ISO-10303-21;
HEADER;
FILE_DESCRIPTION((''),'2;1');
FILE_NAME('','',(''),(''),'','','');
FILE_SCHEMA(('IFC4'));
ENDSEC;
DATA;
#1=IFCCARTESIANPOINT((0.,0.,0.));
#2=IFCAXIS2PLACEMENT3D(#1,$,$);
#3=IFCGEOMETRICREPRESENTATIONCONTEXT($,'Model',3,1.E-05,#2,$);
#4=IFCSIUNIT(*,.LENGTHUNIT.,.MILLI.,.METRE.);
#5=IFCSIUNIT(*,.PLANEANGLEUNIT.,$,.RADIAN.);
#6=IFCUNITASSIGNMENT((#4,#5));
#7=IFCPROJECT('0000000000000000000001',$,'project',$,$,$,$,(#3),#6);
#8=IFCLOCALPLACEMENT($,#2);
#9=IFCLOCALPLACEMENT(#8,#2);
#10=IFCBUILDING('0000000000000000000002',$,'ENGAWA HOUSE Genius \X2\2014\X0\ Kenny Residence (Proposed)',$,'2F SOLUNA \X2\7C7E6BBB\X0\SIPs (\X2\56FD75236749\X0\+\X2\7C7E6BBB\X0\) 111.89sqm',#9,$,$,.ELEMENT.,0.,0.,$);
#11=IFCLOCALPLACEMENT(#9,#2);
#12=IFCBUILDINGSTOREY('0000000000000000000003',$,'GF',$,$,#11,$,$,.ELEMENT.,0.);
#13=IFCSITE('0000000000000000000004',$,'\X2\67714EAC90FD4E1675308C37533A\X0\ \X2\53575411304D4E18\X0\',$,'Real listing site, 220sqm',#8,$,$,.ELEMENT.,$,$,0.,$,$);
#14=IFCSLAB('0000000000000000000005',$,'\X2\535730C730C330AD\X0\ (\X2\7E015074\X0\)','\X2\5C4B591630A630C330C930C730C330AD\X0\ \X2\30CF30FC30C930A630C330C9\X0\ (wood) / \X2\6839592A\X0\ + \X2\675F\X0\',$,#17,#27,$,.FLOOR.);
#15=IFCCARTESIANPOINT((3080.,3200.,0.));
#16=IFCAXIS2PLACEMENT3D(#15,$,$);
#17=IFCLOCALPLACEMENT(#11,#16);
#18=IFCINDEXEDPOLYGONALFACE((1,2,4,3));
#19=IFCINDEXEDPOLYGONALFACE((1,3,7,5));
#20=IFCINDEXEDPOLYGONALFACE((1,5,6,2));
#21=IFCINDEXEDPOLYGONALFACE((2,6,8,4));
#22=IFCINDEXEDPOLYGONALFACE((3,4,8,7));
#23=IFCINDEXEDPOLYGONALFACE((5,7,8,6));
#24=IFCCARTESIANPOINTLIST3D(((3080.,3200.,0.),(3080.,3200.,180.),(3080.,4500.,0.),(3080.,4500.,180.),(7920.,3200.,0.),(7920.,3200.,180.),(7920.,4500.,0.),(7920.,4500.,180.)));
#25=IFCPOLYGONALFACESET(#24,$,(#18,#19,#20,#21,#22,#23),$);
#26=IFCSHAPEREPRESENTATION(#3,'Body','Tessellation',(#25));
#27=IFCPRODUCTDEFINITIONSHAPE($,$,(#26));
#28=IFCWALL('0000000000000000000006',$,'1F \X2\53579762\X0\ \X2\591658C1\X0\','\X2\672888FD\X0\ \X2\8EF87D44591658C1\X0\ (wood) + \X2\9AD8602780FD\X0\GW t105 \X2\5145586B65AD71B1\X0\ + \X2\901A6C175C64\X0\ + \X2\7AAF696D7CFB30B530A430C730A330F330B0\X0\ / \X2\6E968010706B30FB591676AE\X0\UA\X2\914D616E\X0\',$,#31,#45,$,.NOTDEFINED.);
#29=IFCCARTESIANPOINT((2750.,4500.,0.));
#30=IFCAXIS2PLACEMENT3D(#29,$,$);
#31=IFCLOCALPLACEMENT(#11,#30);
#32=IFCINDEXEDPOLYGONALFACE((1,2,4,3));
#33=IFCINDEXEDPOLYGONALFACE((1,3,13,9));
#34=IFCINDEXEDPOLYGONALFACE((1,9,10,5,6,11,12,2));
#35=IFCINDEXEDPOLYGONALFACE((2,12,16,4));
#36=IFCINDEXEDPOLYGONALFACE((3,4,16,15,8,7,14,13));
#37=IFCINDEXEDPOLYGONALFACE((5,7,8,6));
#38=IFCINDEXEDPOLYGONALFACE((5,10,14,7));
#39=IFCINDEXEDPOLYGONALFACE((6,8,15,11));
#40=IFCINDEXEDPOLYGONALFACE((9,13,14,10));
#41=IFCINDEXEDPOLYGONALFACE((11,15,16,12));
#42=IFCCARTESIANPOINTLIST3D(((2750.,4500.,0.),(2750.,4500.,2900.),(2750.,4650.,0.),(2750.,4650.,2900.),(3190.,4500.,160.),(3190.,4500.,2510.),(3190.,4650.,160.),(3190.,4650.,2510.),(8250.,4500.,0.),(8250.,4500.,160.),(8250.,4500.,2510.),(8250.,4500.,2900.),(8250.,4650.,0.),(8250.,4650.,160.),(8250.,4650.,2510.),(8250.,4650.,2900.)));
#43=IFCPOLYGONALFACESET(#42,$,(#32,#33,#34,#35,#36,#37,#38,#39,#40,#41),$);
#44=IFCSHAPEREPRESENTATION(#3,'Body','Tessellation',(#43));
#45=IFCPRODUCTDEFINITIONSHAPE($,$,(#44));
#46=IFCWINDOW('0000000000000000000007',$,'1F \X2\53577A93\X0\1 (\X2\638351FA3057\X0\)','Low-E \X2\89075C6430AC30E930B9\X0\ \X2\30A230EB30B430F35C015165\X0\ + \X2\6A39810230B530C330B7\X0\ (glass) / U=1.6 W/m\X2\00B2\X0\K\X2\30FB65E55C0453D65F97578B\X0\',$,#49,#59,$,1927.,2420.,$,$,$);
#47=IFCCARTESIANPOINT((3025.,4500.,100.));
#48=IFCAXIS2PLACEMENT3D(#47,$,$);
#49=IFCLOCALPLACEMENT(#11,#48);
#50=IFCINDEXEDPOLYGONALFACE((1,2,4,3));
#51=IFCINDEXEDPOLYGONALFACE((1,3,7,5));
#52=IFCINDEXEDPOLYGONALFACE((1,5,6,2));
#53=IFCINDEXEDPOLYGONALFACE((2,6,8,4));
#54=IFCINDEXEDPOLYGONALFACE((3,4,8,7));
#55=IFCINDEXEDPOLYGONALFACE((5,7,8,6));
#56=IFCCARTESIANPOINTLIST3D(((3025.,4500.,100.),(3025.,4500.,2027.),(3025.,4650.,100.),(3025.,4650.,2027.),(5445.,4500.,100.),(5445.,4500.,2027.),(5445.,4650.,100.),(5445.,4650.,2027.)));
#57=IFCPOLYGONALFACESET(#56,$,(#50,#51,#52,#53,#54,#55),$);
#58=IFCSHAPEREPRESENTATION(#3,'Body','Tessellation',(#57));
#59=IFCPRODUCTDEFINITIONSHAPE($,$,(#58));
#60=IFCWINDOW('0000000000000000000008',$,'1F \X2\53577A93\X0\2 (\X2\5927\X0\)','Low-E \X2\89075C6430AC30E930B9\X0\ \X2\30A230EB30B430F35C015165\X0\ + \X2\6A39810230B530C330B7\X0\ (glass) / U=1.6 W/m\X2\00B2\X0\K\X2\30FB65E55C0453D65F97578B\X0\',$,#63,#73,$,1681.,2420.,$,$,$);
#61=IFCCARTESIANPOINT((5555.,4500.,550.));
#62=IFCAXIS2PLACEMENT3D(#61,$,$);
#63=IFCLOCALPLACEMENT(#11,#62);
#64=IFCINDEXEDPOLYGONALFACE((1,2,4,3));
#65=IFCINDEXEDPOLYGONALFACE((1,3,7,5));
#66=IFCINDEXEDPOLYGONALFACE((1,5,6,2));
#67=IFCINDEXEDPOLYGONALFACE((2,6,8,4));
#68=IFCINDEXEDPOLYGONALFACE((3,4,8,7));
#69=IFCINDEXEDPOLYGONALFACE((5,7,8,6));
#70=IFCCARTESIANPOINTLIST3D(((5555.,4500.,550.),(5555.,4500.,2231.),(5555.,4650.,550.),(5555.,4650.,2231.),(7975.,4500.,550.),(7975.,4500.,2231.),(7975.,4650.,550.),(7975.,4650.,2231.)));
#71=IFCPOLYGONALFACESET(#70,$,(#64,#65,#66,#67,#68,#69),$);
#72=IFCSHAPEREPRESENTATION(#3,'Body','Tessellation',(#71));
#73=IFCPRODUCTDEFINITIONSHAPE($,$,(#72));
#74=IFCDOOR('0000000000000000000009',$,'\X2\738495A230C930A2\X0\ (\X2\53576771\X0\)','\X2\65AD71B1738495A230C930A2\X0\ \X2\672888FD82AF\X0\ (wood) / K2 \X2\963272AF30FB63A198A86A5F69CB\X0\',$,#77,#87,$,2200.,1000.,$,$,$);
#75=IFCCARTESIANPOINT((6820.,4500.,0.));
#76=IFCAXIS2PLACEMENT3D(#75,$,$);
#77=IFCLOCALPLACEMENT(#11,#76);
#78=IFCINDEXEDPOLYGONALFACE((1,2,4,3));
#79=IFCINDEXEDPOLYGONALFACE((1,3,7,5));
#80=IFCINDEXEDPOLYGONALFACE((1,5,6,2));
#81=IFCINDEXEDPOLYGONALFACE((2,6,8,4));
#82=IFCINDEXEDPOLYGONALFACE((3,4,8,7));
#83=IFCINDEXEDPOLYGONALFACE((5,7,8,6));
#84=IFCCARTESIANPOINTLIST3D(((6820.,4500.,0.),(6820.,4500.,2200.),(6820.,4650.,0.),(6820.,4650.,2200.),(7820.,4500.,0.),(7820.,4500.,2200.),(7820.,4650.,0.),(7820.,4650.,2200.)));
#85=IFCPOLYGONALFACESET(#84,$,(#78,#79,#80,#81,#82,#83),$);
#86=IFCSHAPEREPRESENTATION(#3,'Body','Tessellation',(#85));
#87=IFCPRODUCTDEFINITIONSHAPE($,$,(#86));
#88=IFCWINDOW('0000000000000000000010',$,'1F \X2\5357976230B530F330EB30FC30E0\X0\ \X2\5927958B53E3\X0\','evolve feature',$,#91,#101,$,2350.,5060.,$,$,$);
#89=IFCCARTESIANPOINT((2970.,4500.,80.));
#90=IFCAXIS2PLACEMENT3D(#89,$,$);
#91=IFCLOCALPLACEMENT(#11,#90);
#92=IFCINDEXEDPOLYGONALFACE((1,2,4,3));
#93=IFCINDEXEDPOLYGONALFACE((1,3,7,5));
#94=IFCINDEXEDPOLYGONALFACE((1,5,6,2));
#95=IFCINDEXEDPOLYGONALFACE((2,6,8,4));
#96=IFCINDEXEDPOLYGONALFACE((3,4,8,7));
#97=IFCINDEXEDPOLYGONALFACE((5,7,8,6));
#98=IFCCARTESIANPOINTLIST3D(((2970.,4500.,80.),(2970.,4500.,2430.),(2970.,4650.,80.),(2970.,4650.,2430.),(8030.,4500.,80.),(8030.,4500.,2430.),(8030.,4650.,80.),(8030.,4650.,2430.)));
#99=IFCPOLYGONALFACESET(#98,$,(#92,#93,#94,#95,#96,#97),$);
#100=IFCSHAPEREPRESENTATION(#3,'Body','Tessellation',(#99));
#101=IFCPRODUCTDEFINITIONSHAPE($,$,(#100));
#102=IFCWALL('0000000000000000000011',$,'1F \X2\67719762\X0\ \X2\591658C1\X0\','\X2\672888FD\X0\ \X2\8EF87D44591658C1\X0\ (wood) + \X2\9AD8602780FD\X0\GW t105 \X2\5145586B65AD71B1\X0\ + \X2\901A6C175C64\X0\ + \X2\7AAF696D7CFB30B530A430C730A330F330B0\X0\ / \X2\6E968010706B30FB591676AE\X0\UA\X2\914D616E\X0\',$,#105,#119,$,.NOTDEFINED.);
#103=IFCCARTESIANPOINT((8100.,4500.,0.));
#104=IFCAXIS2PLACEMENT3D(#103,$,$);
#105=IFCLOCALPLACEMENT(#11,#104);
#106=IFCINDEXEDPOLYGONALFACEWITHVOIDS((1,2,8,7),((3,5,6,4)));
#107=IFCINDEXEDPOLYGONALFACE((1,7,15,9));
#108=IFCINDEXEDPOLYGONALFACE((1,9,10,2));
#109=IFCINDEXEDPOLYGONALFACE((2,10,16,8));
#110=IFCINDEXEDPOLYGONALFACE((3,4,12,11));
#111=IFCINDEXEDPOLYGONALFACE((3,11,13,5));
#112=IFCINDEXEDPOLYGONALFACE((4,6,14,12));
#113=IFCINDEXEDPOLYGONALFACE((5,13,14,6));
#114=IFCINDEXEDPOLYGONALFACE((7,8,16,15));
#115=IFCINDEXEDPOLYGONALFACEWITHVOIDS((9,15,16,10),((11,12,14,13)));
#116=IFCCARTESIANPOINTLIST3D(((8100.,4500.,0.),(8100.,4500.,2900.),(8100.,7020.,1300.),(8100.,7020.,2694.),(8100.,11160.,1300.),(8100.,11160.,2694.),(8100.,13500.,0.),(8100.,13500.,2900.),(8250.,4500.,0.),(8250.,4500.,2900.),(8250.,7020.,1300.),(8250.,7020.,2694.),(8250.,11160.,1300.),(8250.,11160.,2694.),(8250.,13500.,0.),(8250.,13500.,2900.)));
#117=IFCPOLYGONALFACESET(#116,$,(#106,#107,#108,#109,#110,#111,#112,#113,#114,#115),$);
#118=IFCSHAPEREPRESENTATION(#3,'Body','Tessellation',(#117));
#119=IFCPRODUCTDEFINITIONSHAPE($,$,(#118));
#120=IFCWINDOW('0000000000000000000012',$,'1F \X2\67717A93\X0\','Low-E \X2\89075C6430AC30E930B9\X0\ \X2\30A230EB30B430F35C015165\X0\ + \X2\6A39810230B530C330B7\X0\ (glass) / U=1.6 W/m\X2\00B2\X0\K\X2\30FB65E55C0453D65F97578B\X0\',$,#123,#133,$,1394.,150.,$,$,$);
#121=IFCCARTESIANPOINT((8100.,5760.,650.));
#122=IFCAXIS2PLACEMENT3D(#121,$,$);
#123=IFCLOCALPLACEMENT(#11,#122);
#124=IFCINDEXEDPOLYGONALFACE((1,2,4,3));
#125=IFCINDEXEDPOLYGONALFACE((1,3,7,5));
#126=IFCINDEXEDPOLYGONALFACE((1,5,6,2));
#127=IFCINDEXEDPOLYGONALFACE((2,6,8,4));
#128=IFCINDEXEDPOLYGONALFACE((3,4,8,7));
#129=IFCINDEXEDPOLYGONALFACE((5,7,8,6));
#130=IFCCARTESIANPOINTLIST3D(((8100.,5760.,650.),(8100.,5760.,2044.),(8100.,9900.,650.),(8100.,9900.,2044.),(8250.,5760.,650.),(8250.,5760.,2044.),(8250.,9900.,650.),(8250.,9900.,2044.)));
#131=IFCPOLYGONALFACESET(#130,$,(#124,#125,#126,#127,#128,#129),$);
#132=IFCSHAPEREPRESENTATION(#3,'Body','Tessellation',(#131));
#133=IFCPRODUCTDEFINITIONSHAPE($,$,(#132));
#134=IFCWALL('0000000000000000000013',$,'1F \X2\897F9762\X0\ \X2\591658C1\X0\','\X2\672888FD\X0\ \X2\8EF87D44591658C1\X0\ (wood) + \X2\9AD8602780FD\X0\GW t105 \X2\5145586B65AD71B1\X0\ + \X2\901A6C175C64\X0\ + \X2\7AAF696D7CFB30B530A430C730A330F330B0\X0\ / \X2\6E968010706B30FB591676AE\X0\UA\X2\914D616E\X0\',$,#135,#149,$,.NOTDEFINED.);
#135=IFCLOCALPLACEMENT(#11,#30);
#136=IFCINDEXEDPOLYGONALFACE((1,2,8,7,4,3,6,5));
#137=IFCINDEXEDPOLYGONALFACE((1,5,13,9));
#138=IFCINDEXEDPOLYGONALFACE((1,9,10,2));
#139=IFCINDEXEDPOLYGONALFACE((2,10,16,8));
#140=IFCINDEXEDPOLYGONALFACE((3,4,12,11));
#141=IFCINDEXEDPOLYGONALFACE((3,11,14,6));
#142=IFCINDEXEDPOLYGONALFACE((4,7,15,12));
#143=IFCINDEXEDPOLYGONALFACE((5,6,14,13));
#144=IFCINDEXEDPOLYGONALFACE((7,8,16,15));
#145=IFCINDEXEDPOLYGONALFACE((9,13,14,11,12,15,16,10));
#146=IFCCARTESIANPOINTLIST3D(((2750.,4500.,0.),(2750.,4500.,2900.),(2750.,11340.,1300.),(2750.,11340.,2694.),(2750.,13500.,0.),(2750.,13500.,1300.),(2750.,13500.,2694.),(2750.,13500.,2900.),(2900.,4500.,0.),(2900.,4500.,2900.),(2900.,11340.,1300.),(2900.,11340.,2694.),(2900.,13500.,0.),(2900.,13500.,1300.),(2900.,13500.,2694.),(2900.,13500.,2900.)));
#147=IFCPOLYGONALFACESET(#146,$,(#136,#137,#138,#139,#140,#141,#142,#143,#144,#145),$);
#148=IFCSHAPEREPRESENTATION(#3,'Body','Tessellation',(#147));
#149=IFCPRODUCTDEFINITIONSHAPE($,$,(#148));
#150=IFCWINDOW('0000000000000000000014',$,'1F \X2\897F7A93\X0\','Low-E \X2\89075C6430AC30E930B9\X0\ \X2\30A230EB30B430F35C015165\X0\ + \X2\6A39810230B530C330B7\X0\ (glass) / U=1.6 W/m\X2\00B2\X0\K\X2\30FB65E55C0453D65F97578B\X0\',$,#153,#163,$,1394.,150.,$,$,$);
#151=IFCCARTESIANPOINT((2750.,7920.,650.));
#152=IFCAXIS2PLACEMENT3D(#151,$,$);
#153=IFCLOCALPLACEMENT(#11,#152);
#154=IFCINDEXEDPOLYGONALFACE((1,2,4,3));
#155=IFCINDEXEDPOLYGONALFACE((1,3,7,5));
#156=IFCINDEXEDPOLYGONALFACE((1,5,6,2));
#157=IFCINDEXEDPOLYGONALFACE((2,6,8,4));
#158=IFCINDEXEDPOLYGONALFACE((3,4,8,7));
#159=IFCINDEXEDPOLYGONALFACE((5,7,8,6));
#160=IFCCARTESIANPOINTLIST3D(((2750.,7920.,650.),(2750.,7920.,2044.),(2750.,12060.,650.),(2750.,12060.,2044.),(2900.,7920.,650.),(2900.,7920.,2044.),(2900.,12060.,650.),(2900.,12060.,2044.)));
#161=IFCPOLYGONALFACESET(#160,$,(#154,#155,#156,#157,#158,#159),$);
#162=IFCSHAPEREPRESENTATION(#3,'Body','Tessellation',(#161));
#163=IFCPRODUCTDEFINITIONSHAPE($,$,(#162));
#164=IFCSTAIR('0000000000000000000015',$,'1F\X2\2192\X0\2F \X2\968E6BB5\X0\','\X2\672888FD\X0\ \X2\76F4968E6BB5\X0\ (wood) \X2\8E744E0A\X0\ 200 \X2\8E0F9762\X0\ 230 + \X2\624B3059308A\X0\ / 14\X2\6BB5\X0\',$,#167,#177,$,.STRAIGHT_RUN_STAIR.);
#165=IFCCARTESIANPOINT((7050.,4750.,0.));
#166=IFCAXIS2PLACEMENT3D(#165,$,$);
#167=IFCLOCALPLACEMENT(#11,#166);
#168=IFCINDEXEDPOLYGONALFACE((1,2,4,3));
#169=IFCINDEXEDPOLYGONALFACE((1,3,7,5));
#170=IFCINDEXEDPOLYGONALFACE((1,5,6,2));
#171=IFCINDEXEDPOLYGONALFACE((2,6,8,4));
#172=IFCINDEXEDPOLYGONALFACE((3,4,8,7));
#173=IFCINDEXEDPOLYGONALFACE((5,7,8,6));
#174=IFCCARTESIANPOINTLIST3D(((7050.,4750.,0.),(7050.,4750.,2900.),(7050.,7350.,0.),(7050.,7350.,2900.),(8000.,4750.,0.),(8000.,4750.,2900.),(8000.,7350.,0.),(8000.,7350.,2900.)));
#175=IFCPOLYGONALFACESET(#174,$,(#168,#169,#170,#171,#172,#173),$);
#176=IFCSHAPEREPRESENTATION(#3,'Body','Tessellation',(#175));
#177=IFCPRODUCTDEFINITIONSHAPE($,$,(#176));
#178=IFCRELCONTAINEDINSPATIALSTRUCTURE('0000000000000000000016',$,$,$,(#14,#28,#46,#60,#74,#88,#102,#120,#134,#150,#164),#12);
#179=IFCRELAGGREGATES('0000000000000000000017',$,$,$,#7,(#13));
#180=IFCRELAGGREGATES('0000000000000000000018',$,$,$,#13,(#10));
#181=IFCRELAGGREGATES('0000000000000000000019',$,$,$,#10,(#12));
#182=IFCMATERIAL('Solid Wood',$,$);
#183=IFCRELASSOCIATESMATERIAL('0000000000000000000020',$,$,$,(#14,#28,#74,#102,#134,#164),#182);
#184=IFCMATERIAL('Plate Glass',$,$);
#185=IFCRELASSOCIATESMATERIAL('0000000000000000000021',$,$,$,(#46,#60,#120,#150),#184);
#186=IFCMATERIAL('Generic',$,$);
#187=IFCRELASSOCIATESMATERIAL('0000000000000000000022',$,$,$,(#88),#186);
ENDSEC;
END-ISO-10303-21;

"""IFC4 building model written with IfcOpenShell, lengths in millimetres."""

from ifc_helpers import new_model, si_unit, frame, frame_2d, origin, place, context, project, spatial, rectangle, extrude, material, element, fill, save


model = new_model("IFC4")

# Units and contexts
model_context = context("Model", 3, precision=1e-05, world=origin())
ifc_project = project(units=[si_unit("LENGTHUNIT", "METRE", prefix="MILLI"), si_unit("PLANEANGLEUNIT", "RADIAN")], contexts=[model_context])

# Site, building, storey
site_placement = place(None, origin())
site = spatial("IfcSite", under=ifc_project, at=site_placement, Name="東京都世田谷区 南向き丘", ObjectType="Real listing site, 220sqm", CompositionType="ELEMENT", RefElevation=0.0)
building_placement = place(site_placement, origin())
building = spatial("IfcBuilding", under=site, at=building_placement, Name="ENGAWA HOUSE Genius — Kenny Residence (Proposed)", ObjectType="2F SOLUNA 籾殻SIPs (国産杉+籾殻) 111.89sqm", CompositionType="ELEMENT", ElevationOfRefHeight=0.0, ElevationOfTerrain=0.0)
storey_placement = place(building_placement, origin())
storey = spatial("IfcBuildingStorey", under=building, at=storey_placement, Name="GF", CompositionType="ELEMENT", Elevation=0.0)

# Slab
ifc_material_1 = material(Name="Solid Wood")
slab_1_placement = place(storey_placement, frame((3080.0, 3200.0, 0.0)))
element("IfcSlab", 1, at=slab_1_placement, inside=storey, material=ifc_material_1, Name="南デッキ (縁側)", Description="屋外ウッドデッキ ハードウッド (wood) / 根太 + 束", PredefinedType="FLOOR", context=model_context, shape_type="SweptSolid", body=[
    extrude(rectangle(XDim=4840.0, YDim=1300.0, at=frame_2d((2420.0, 650.0))), frame((3080.0, 3200.0, 0.0)), (0.0, 0.0, 1.0), 180.0),
])
ifc_material_2 = material(Name="Generic")

# Wall, openings, windows, door
wall_1_placement = place(storey_placement, frame((2750.0, 4500.0, 0.0)))
wall_1 = element("IfcWall", 2, at=wall_1_placement, inside=storey, material=ifc_material_1, Name="1F 南面 外壁", Description="木製 軸組外壁 (wood) + 高性能GW t105 充填断熱 + 通気層 + 窯業系サイディング / 準耐火・外皮UA配慮", PredefinedType="NOTDEFINED", context=model_context, shape_type="SweptSolid", body=[
    extrude(rectangle(XDim=5500.0, YDim=150.0, at=frame_2d((2750.0, 75.0))), frame((2750.0, 4500.0, 0.0)), (0.0, 0.0, 1.0), 2900.0),
])
opening_1_placement = place(storey_placement, frame((3025.0, 4500.0, 100.0)))
opening_1 = element("IfcOpeningElement", 3, at=opening_1_placement, cuts=wall_1, PredefinedType="NOTDEFINED", context=model_context, shape_type="SweptSolid", body=[
    extrude(rectangle(XDim=2420.0, YDim=150.0, at=frame_2d((1210.0, 75.0))), frame((3025.0, 4500.0, 100.0)), (0.0, 0.0, 1.0), 1927.0),
])
opening_2_placement = place(storey_placement, frame((5555.0, 4500.0, 550.0)))
opening_2 = element("IfcOpeningElement", 4, at=opening_2_placement, cuts=wall_1, PredefinedType="NOTDEFINED", context=model_context, shape_type="SweptSolid", body=[
    extrude(rectangle(XDim=2420.0, YDim=150.0, at=frame_2d((1210.0, 75.0))), frame((5555.0, 4500.0, 550.0)), (0.0, 0.0, 1.0), 1681.0),
])
opening_3_placement = place(storey_placement, frame((6820.0, 4500.0, 0.0)))
opening_3 = element("IfcOpeningElement", 5, at=opening_3_placement, cuts=wall_1, PredefinedType="NOTDEFINED", context=model_context, shape_type="SweptSolid", body=[
    extrude(rectangle(XDim=1000.0, YDim=150.0, at=frame_2d((500.0, 75.0))), frame((6820.0, 4500.0, 0.0)), (0.0, 0.0, 1.0), 2200.0),
])
opening_4_placement = place(storey_placement, frame((2970.0, 4500.0, 80.0)))
opening_4 = element("IfcOpeningElement", 6, at=opening_4_placement, cuts=wall_1, PredefinedType="NOTDEFINED", context=model_context, shape_type="SweptSolid", body=[
    extrude(rectangle(XDim=5060.0, YDim=150.0, at=frame_2d((2530.0, 75.0))), frame((2970.0, 4500.0, 80.0)), (0.0, 0.0, 1.0), 2350.0),
])
ifc_material_3 = material(Name="Plate Glass")
window_1_placement = place(storey_placement, frame((3025.0, 4500.0, 100.0)))
window_1 = element("IfcWindow", 7, at=window_1_placement, inside=storey, material=ifc_material_3, Name="1F 南窓1 (掃出し)", Description="Low-E 複層ガラス アルゴン封入 + 樹脂サッシ (glass) / U=1.6 W/m²K・日射取得型", OverallHeight=1927.0, OverallWidth=2420.0, context=model_context, shape_type="SweptSolid", body=[
    extrude(rectangle(XDim=2420.0, YDim=150.0, at=frame_2d((1210.0, 75.0))), frame((3025.0, 4500.0, 100.0)), (0.0, 0.0, 1.0), 1927.0),
])
fill(opening_1, window_1)
window_2_placement = place(storey_placement, frame((5555.0, 4500.0, 550.0)))
window_2 = element("IfcWindow", 8, at=window_2_placement, inside=storey, material=ifc_material_3, Name="1F 南窓2 (大)", Description="Low-E 複層ガラス アルゴン封入 + 樹脂サッシ (glass) / U=1.6 W/m²K・日射取得型", OverallHeight=1681.0, OverallWidth=2420.0, context=model_context, shape_type="SweptSolid", body=[
    extrude(rectangle(XDim=2420.0, YDim=150.0, at=frame_2d((1210.0, 75.0))), frame((5555.0, 4500.0, 550.0)), (0.0, 0.0, 1.0), 1681.0),
])
fill(opening_2, window_2)
door_placement = place(storey_placement, frame((6820.0, 4500.0, 0.0)))
door = element("IfcDoor", 9, at=door_placement, inside=storey, material=ifc_material_1, Name="玄関ドア (南東)", Description="断熱玄関ドア 木製芯 (wood) / K2 防犯・採風機構", OverallHeight=2200.0, OverallWidth=1000.0, context=model_context, shape_type="SweptSolid", body=[
    extrude(rectangle(XDim=1000.0, YDim=150.0, at=frame_2d((500.0, 75.0))), frame((6820.0, 4500.0, 0.0)), (0.0, 0.0, 1.0), 2200.0),
])
fill(opening_3, door)
window_3_placement = place(storey_placement, frame((2970.0, 4500.0, 80.0)))
window_3 = element("IfcWindow", 10, at=window_3_placement, inside=storey, material=ifc_material_2, Name="1F 南面サンルーム 大開口", Description="evolve feature", OverallHeight=2350.0, OverallWidth=5060.0, context=model_context, shape_type="SweptSolid", body=[
    extrude(rectangle(XDim=5060.0, YDim=150.0, at=frame_2d((2530.0, 75.0))), frame((2970.0, 4500.0, 80.0)), (0.0, 0.0, 1.0), 2350.0),
])
fill(opening_4, window_3)

# Walls, openings, windows
wall_2_placement = place(storey_placement, frame((8100.0, 4500.0, 0.0)))
wall_2 = element("IfcWall", 11, at=wall_2_placement, inside=storey, material=ifc_material_1, Name="1F 東面 外壁", Description="木製 軸組外壁 (wood) + 高性能GW t105 充填断熱 + 通気層 + 窯業系サイディング / 準耐火・外皮UA配慮", PredefinedType="NOTDEFINED", context=model_context, shape_type="SweptSolid", body=[
    extrude(rectangle(XDim=150.0, YDim=9000.0, at=frame_2d((75.0, 4500.0))), frame((8100.0, 4500.0, 0.0)), (0.0, 0.0, 1.0), 2900.0),
])
opening_5_placement = place(storey_placement, frame((8100.0, 5760.0, 650.0)))
opening_5 = element("IfcOpeningElement", 12, at=opening_5_placement, cuts=wall_2, PredefinedType="NOTDEFINED", context=model_context, shape_type="SweptSolid", body=[
    extrude(rectangle(XDim=150.0, YDim=4140.0, at=frame_2d((75.0, 2070.0))), frame((8100.0, 5760.0, 650.0)), (0.0, 0.0, 1.0), 1394.0),
])
window_4_placement = place(storey_placement, frame((8100.0, 5760.0, 650.0)))
window_4 = element("IfcWindow", 13, at=window_4_placement, inside=storey, material=ifc_material_3, Name="1F 東窓", Description="Low-E 複層ガラス アルゴン封入 + 樹脂サッシ (glass) / U=1.6 W/m²K・日射取得型", OverallHeight=1394.0, OverallWidth=150.0, context=model_context, shape_type="SweptSolid", body=[
    extrude(rectangle(XDim=150.0, YDim=4140.0, at=frame_2d((75.0, 2070.0))), frame((8100.0, 5760.0, 650.0)), (0.0, 0.0, 1.0), 1394.0),
])
fill(opening_5, window_4)
wall_3_placement = place(storey_placement, frame((2750.0, 4500.0, 0.0)))
wall_3 = element("IfcWall", 14, at=wall_3_placement, inside=storey, material=ifc_material_1, Name="1F 西面 外壁", Description="木製 軸組外壁 (wood) + 高性能GW t105 充填断熱 + 通気層 + 窯業系サイディング / 準耐火・外皮UA配慮", PredefinedType="NOTDEFINED", context=model_context, shape_type="SweptSolid", body=[
    extrude(rectangle(XDim=150.0, YDim=9000.0, at=frame_2d((75.0, 4500.0))), frame((2750.0, 4500.0, 0.0)), (0.0, 0.0, 1.0), 2900.0),
])
opening_6_placement = place(storey_placement, frame((2750.0, 7920.0, 650.0)))
opening_6 = element("IfcOpeningElement", 15, at=opening_6_placement, cuts=wall_3, PredefinedType="NOTDEFINED", context=model_context, shape_type="SweptSolid", body=[
    extrude(rectangle(XDim=150.0, YDim=4140.0, at=frame_2d((75.0, 2070.0))), frame((2750.0, 7920.0, 650.0)), (0.0, 0.0, 1.0), 1394.0),
])
window_5_placement = place(storey_placement, frame((2750.0, 7920.0, 650.0)))
window_5 = element("IfcWindow", 16, at=window_5_placement, inside=storey, material=ifc_material_3, Name="1F 西窓", Description="Low-E 複層ガラス アルゴン封入 + 樹脂サッシ (glass) / U=1.6 W/m²K・日射取得型", OverallHeight=1394.0, OverallWidth=150.0, context=model_context, shape_type="SweptSolid", body=[
    extrude(rectangle(XDim=150.0, YDim=4140.0, at=frame_2d((75.0, 2070.0))), frame((2750.0, 7920.0, 650.0)), (0.0, 0.0, 1.0), 1394.0),
])
fill(opening_6, window_5)

# Stair
stair_placement = place(storey_placement, frame((7050.0, 4750.0, 0.0)))
element("IfcStair", 17, at=stair_placement, inside=storey, material=ifc_material_1, Name="1F→2F 階段", Description="木製 直階段 (wood) 蹴上 200 踏面 230 + 手すり / 14段", PredefinedType="STRAIGHT_RUN_STAIR", context=model_context, shape_type="SweptSolid", body=[
    extrude(rectangle(XDim=950.0, YDim=2600.0, at=frame_2d((475.0, 1300.0))), frame((7050.0, 4750.0, 0.0)), (0.0, 0.0, 1.0), 2900.0),
])

save(model, "model.ifc")
